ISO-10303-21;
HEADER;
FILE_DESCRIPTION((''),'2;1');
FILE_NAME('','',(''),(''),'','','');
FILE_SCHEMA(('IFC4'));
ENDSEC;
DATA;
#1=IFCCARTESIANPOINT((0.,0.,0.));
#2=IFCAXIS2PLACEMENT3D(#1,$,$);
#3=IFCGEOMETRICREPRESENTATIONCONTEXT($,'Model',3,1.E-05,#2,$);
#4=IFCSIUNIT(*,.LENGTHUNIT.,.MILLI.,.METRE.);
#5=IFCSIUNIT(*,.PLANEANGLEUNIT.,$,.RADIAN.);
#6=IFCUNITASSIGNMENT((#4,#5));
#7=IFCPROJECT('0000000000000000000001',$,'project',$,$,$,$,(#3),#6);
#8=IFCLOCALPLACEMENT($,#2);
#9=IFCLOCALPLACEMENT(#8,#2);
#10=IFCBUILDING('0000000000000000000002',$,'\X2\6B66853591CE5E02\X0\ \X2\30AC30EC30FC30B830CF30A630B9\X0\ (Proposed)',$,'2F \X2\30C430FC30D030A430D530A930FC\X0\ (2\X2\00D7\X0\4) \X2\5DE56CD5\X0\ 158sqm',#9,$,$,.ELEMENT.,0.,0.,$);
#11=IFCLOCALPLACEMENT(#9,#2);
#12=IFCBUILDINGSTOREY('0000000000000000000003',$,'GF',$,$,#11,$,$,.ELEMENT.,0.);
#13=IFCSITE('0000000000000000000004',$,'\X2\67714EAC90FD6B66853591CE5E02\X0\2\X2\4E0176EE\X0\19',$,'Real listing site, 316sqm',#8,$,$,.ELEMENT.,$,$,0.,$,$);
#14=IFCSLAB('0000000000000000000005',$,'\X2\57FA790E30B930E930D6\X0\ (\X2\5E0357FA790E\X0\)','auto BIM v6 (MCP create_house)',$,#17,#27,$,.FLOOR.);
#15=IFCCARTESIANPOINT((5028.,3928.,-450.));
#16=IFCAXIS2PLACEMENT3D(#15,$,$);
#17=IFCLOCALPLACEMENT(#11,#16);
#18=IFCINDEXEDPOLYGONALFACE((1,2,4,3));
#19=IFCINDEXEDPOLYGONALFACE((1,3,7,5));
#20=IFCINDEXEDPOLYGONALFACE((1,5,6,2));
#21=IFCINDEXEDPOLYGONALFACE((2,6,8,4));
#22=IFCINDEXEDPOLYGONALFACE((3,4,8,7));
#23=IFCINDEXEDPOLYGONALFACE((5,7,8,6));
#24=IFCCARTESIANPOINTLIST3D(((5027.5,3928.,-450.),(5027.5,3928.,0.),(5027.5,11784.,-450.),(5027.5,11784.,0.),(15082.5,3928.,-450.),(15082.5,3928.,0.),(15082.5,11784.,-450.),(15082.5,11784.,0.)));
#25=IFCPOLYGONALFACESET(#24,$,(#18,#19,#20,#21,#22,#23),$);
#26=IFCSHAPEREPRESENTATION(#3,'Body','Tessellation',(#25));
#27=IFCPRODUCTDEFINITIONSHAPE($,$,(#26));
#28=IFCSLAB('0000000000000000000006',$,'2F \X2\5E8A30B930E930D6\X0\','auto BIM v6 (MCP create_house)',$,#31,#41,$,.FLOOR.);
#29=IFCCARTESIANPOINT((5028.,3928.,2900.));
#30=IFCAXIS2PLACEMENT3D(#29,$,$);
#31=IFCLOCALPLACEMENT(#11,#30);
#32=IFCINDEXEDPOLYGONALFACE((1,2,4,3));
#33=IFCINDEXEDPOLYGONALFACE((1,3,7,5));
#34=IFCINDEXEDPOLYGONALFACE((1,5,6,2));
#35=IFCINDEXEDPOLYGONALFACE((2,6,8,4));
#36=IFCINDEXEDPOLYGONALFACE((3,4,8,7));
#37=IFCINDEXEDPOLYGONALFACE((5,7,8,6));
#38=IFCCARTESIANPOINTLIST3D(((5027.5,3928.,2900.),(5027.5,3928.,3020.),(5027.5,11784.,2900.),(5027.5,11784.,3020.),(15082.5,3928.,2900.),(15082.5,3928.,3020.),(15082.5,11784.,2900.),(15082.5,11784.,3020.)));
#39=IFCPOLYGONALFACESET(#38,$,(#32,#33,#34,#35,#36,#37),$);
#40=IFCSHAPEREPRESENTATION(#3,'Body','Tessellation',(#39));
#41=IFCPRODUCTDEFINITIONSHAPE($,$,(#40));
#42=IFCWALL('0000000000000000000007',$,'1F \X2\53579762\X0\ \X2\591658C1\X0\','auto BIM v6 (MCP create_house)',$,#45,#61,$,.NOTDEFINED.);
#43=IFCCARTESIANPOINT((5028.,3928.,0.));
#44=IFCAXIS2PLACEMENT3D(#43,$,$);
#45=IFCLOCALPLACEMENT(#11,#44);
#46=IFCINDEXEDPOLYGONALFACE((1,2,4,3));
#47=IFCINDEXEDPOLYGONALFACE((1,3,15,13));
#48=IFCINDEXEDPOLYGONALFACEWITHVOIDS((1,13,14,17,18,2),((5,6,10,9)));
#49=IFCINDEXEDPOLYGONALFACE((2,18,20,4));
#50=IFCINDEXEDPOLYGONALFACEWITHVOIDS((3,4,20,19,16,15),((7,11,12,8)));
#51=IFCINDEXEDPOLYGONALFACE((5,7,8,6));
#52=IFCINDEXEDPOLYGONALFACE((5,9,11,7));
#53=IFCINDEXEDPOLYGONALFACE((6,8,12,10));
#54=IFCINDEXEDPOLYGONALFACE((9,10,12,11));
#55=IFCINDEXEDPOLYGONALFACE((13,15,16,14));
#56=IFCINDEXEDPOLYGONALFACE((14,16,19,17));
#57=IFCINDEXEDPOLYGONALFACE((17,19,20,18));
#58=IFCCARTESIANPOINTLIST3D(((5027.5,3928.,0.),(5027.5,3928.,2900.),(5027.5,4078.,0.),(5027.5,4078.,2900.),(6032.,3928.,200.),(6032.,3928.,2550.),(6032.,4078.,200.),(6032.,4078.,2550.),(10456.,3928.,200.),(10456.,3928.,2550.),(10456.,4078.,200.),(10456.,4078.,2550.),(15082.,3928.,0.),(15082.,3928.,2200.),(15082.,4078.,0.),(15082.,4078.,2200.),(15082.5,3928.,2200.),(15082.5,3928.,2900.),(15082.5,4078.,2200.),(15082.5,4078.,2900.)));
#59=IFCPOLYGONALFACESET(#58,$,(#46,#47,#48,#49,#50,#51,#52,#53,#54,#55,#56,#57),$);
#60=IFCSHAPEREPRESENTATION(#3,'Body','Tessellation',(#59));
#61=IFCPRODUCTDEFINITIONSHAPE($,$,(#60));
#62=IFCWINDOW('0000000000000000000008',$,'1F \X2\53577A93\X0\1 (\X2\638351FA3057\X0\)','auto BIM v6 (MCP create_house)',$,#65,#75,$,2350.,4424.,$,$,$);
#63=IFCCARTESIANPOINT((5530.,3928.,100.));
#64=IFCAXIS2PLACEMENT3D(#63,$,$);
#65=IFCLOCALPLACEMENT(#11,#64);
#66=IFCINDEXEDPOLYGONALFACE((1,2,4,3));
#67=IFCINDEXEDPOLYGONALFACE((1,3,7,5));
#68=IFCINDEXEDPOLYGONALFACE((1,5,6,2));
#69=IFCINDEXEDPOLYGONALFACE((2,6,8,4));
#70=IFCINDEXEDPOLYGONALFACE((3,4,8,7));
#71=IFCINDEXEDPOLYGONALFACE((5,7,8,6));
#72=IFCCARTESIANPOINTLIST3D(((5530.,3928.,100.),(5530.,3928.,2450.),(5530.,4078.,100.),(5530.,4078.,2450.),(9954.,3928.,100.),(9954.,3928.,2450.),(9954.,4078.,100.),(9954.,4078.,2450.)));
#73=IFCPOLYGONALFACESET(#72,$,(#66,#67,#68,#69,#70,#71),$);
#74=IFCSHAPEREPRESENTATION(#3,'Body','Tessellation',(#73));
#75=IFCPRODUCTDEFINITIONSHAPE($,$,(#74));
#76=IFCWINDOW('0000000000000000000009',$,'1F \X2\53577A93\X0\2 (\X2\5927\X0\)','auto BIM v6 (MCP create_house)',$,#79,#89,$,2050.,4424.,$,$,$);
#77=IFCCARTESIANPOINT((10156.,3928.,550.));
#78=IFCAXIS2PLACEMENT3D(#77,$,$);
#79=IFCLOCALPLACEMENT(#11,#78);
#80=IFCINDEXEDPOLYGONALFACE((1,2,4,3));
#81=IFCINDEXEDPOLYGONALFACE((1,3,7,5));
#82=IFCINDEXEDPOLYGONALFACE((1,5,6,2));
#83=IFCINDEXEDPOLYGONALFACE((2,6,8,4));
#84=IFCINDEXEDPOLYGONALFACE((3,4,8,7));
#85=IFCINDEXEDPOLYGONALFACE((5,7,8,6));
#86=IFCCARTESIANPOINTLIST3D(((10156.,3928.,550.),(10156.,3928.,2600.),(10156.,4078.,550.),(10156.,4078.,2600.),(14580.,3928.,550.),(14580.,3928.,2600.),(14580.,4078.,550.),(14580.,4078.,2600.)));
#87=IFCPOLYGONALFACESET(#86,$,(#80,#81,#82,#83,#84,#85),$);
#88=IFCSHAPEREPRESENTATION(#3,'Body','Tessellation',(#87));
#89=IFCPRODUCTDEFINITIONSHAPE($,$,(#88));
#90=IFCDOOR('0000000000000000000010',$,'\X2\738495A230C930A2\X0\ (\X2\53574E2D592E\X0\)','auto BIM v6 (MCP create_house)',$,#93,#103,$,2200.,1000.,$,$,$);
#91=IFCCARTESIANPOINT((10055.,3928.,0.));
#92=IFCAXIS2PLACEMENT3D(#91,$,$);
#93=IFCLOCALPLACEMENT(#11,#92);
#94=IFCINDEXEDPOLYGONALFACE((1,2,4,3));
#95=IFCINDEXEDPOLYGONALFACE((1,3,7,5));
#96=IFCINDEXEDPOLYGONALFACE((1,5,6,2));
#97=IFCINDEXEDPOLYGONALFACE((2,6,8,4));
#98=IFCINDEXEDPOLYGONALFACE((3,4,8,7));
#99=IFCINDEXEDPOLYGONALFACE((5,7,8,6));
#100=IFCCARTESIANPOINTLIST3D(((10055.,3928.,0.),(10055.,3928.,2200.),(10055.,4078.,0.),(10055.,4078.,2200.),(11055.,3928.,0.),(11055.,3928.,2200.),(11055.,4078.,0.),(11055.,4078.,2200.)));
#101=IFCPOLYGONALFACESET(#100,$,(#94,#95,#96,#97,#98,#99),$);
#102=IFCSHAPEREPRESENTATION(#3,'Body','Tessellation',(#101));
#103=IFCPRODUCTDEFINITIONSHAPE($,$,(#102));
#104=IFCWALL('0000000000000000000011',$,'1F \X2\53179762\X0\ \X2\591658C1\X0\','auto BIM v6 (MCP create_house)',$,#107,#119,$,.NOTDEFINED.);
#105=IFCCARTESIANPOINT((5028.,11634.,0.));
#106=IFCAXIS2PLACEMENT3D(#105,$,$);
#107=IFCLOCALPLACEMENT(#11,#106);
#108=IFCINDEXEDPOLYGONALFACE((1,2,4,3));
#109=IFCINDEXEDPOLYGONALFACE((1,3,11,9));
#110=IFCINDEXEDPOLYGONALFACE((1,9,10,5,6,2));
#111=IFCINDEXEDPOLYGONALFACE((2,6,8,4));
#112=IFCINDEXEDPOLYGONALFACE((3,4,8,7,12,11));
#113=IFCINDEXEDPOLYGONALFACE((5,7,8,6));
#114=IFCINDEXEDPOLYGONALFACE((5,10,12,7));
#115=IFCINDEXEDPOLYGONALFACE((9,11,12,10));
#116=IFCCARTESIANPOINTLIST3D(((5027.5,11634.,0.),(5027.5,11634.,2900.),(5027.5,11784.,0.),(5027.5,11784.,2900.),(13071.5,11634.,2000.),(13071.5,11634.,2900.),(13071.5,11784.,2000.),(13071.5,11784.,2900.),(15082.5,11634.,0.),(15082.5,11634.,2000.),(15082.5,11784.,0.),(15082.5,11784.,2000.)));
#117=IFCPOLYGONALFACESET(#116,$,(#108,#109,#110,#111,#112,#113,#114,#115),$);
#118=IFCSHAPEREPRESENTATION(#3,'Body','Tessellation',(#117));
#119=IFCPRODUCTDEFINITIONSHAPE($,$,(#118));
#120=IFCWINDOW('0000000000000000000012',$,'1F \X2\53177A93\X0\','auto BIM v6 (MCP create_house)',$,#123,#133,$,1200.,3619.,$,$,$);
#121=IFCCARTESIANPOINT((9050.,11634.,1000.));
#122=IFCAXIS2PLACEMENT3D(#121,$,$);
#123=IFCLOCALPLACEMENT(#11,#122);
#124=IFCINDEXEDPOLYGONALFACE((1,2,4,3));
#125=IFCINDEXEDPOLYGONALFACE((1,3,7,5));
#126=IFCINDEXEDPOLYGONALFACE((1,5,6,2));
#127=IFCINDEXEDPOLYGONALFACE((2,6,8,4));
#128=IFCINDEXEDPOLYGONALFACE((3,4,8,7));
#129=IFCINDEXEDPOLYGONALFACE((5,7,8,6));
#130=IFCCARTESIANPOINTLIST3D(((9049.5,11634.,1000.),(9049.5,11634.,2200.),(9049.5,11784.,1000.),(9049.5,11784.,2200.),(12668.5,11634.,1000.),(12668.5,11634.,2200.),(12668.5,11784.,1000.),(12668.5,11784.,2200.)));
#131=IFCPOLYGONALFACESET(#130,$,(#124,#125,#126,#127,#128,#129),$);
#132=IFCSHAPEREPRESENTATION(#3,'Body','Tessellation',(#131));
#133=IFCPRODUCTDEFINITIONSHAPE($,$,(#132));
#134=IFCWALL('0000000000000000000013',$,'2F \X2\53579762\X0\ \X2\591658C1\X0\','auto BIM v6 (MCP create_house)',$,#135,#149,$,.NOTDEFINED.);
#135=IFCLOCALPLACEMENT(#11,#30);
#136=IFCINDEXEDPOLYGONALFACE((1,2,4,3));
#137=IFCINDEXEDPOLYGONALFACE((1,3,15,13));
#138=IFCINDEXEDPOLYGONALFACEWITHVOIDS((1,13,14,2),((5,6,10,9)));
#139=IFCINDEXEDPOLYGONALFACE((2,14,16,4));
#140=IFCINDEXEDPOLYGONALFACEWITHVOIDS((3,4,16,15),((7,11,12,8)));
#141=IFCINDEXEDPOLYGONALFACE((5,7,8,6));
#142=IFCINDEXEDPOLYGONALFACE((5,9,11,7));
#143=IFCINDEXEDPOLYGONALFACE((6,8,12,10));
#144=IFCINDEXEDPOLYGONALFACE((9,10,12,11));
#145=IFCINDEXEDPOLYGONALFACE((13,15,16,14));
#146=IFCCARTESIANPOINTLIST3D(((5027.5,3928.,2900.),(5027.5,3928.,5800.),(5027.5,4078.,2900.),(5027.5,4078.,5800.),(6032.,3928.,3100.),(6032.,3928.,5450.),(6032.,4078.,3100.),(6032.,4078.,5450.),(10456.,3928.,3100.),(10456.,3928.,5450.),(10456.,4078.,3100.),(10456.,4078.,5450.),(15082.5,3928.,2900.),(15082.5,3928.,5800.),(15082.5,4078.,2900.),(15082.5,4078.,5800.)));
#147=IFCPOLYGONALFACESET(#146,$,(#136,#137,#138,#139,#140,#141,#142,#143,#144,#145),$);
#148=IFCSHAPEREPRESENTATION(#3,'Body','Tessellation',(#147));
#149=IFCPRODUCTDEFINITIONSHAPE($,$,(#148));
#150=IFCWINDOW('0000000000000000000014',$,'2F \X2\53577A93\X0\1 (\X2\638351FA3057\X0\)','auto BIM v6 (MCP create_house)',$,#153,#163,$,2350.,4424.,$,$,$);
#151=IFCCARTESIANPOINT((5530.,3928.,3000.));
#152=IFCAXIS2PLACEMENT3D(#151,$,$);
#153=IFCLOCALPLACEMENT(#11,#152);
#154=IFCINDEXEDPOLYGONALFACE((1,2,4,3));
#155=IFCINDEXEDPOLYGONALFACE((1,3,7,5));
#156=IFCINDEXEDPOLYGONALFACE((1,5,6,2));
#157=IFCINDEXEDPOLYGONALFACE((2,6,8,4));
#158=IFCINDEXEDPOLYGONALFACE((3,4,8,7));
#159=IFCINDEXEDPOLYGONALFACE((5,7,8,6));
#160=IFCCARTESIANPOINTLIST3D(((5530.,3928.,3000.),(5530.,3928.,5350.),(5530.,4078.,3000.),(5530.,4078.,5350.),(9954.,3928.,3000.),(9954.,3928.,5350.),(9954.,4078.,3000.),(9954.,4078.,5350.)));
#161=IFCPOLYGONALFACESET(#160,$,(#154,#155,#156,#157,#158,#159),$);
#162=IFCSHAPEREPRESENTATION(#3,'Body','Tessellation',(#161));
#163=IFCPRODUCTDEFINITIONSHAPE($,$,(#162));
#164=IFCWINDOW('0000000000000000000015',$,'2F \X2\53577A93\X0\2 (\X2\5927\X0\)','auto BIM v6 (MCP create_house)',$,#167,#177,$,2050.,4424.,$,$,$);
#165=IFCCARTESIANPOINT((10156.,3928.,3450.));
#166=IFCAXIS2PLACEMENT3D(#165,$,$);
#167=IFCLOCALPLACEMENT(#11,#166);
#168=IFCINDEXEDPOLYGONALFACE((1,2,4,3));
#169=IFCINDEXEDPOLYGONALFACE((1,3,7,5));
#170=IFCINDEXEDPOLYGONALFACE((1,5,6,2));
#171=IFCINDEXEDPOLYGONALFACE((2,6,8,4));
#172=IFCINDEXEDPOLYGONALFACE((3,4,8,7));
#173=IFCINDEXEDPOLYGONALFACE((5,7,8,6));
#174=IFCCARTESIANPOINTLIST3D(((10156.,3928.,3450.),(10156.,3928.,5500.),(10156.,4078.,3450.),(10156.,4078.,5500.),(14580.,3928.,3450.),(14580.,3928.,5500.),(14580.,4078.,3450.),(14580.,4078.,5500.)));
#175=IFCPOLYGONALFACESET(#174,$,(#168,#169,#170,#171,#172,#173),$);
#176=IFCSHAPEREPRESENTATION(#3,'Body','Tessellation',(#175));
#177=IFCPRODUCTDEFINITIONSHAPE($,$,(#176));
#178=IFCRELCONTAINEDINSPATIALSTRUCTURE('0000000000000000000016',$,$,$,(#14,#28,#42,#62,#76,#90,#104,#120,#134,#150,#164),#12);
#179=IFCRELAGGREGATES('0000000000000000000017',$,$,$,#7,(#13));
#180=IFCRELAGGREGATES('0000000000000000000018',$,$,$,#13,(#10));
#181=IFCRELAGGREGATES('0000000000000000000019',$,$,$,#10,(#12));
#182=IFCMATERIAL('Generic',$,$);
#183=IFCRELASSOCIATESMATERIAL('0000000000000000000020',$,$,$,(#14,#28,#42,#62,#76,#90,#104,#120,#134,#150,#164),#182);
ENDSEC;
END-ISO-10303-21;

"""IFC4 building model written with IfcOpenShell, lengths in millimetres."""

from ifc_helpers import new_model, si_unit, frame, frame_2d, origin, place, context, project, spatial, rectangle, extrude, material, element, fill, save


model = new_model("IFC4")

# Units and contexts
model_context = context("Model", 3, precision=1e-05, world=origin())
ifc_project = project(units=[si_unit("LENGTHUNIT", "METRE", prefix="MILLI"), si_unit("PLANEANGLEUNIT", "RADIAN")], contexts=[model_context])

# Site, building, storey
site_placement = place(None, origin())
site = spatial("IfcSite", under=ifc_project, at=site_placement, Name="東京都武蔵野市2丁目19", ObjectType="Real listing site, 316sqm", CompositionType="ELEMENT", RefElevation=0.0)
building_placement = place(site_placement, origin())
building = spatial("IfcBuilding", under=site, at=building_placement, Name="武蔵野市 ガレージハウス (Proposed)", ObjectType="2F ツーバイフォー (2×4) 工法 158sqm", CompositionType="ELEMENT", ElevationOfRefHeight=0.0, ElevationOfTerrain=0.0)
storey_placement = place(building_placement, origin())
storey = spatial("IfcBuildingStorey", under=building, at=storey_placement, Name="GF", CompositionType="ELEMENT", Elevation=0.0)

# Slabs
ifc_material = material(Name="Generic")
slab_1_placement = place(storey_placement, frame((5028.0, 3928.0, -450.0)))
element("IfcSlab", 1, at=slab_1_placement, inside=storey, material=ifc_material, Name="基礎スラブ (布基礎)", Description="auto BIM v6 (MCP create_house)", PredefinedType="FLOOR", context=model_context, shape_type="SweptSolid", body=[
    extrude(rectangle(XDim=10055.0, YDim=7856.0, at=frame_2d((5027.0, 3928.0))), frame((5028.0, 3928.0, -450.0)), (0.0, 0.0, 1.0), 450.0),
])
slab_2_placement = place(storey_placement, frame((5028.0, 3928.0, 2900.0)))
element("IfcSlab", 2, at=slab_2_placement, inside=storey, material=ifc_material, Name="2F 床スラブ", Description="auto BIM v6 (MCP create_house)", PredefinedType="FLOOR", context=model_context, shape_type="SweptSolid", body=[
    extrude(rectangle(XDim=10055.0, YDim=7856.0, at=frame_2d((5027.0, 3928.0))), frame((5028.0, 3928.0, 2900.0)), (0.0, 0.0, 1.0), 120.0),
])

# Wall, openings, windows, door
wall_1_placement = place(storey_placement, frame((5028.0, 3928.0, 0.0)))
wall_1 = element("IfcWall", 3, at=wall_1_placement, inside=storey, material=ifc_material, Name="1F 南面 外壁", Description="auto BIM v6 (MCP create_house)", PredefinedType="NOTDEFINED", context=model_context, shape_type="SweptSolid", body=[
    extrude(rectangle(XDim=10055.0, YDim=150.0, at=frame_2d((5027.0, 75.0))), frame((5028.0, 3928.0, 0.0)), (0.0, 0.0, 1.0), 2900.0),
])
opening_1_placement = place(storey_placement, frame((5530.0, 3928.0, 100.0)))
opening_1 = element("IfcOpeningElement", 4, at=opening_1_placement, cuts=wall_1, PredefinedType="NOTDEFINED", context=model_context, shape_type="SweptSolid", body=[
    extrude(rectangle(XDim=4424.0, YDim=150.0, at=frame_2d((2212.0, 75.0))), frame((5530.0, 3928.0, 100.0)), (0.0, 0.0, 1.0), 2350.0),
])
opening_2_placement = place(storey_placement, frame((10156.0, 3928.0, 550.0)))
opening_2 = element("IfcOpeningElement", 5, at=opening_2_placement, cuts=wall_1, PredefinedType="NOTDEFINED", context=model_context, shape_type="SweptSolid", body=[
    extrude(rectangle(XDim=4424.0, YDim=150.0, at=frame_2d((2212.0, 75.0))), frame((10156.0, 3928.0, 550.0)), (0.0, 0.0, 1.0), 2050.0),
])
opening_3_placement = place(storey_placement, frame((10055.0, 3928.0, 0.0)))
opening_3 = element("IfcOpeningElement", 6, at=opening_3_placement, cuts=wall_1, PredefinedType="NOTDEFINED", context=model_context, shape_type="SweptSolid", body=[
    extrude(rectangle(XDim=1000.0, YDim=150.0, at=frame_2d((500.0, 75.0))), frame((10055.0, 3928.0, 0.0)), (0.0, 0.0, 1.0), 2200.0),
])
window_1_placement = place(storey_placement, frame((5530.0, 3928.0, 100.0)))
window_1 = element("IfcWindow", 7, at=window_1_placement, inside=storey, material=ifc_material, Name="1F 南窓1 (掃出し)", Description="auto BIM v6 (MCP create_house)", OverallHeight=2350.0, OverallWidth=4424.0, context=model_context, shape_type="SweptSolid", body=[
    extrude(rectangle(XDim=4424.0, YDim=150.0, at=frame_2d((2212.0, 75.0))), frame((5530.0, 3928.0, 100.0)), (0.0, 0.0, 1.0), 2350.0),
])
fill(opening_1, window_1)
window_2_placement = place(storey_placement, frame((10156.0, 3928.0, 550.0)))
window_2 = element("IfcWindow", 8, at=window_2_placement, inside=storey, material=ifc_material, Name="1F 南窓2 (大)", Description="auto BIM v6 (MCP create_house)", OverallHeight=2050.0, OverallWidth=4424.0, context=model_context, shape_type="SweptSolid", body=[
    extrude(rectangle(XDim=4424.0, YDim=150.0, at=frame_2d((2212.0, 75.0))), frame((10156.0, 3928.0, 550.0)), (0.0, 0.0, 1.0), 2050.0),
])
fill(opening_2, window_2)
door_placement = place(storey_placement, frame((10055.0, 3928.0, 0.0)))
door = element("IfcDoor", 9, at=door_placement, inside=storey, material=ifc_material, Name="玄関ドア (南中央)", Description="auto BIM v6 (MCP create_house)", OverallHeight=2200.0, OverallWidth=1000.0, context=model_context, shape_type="SweptSolid", body=[
    extrude(rectangle(XDim=1000.0, YDim=150.0, at=frame_2d((500.0, 75.0))), frame((10055.0, 3928.0, 0.0)), (0.0, 0.0, 1.0), 2200.0),
])
fill(opening_3, door)

# Wall, opening, window
wall_2_placement = place(storey_placement, frame((5028.0, 11634.0, 0.0)))
wall_2 = element("IfcWall", 10, at=wall_2_placement, inside=storey, material=ifc_material, Name="1F 北面 外壁", Description="auto BIM v6 (MCP create_house)", PredefinedType="NOTDEFINED", context=model_context, shape_type="SweptSolid", body=[
    extrude(rectangle(XDim=10055.0, YDim=150.0, at=frame_2d((5027.0, 75.0))), frame((5028.0, 11634.0, 0.0)), (0.0, 0.0, 1.0), 2900.0),
])
opening_4_placement = place(storey_placement, frame((9050.0, 11634.0, 1000.0)))
opening_4 = element("IfcOpeningElement", 11, at=opening_4_placement, cuts=wall_2, PredefinedType="NOTDEFINED", context=model_context, shape_type="SweptSolid", body=[
    extrude(rectangle(XDim=3619.0, YDim=150.0, at=frame_2d((1809.0, 75.0))), frame((9050.0, 11634.0, 1000.0)), (0.0, 0.0, 1.0), 1200.0),
])
window_3_placement = place(storey_placement, frame((9050.0, 11634.0, 1000.0)))
window_3 = element("IfcWindow", 12, at=window_3_placement, inside=storey, material=ifc_material, Name="1F 北窓", Description="auto BIM v6 (MCP create_house)", OverallHeight=1200.0, OverallWidth=3619.0, context=model_context, shape_type="SweptSolid", body=[
    extrude(rectangle(XDim=3619.0, YDim=150.0, at=frame_2d((1809.0, 75.0))), frame((9050.0, 11634.0, 1000.0)), (0.0, 0.0, 1.0), 1200.0),
])
fill(opening_4, window_3)

# Wall, openings, windows
wall_3_placement = place(storey_placement, frame((5028.0, 3928.0, 2900.0)))
wall_3 = element("IfcWall", 13, at=wall_3_placement, inside=storey, material=ifc_material, Name="2F 南面 外壁", Description="auto BIM v6 (MCP create_house)", PredefinedType="NOTDEFINED", context=model_context, shape_type="SweptSolid", body=[
    extrude(rectangle(XDim=10055.0, YDim=150.0, at=frame_2d((5027.0, 75.0))), frame((5028.0, 3928.0, 2900.0)), (0.0, 0.0, 1.0), 2900.0),
])
opening_5_placement = place(storey_placement, frame((5530.0, 3928.0, 3000.0)))
opening_5 = element("IfcOpeningElement", 14, at=opening_5_placement, cuts=wall_3, PredefinedType="NOTDEFINED", context=model_context, shape_type="SweptSolid", body=[
    extrude(rectangle(XDim=4424.0, YDim=150.0, at=frame_2d((2212.0, 75.0))), frame((5530.0, 3928.0, 3000.0)), (0.0, 0.0, 1.0), 2350.0),
])
opening_6_placement = place(storey_placement, frame((10156.0, 3928.0, 3450.0)))
opening_6 = element("IfcOpeningElement", 15, at=opening_6_placement, cuts=wall_3, PredefinedType="NOTDEFINED", context=model_context, shape_type="SweptSolid", body=[
    extrude(rectangle(XDim=4424.0, YDim=150.0, at=frame_2d((2212.0, 75.0))), frame((10156.0, 3928.0, 3450.0)), (0.0, 0.0, 1.0), 2050.0),
])
window_4_placement = place(storey_placement, frame((5530.0, 3928.0, 3000.0)))
window_4 = element("IfcWindow", 16, at=window_4_placement, inside=storey, material=ifc_material, Name="2F 南窓1 (掃出し)", Description="auto BIM v6 (MCP create_house)", OverallHeight=2350.0, OverallWidth=4424.0, context=model_context, shape_type="SweptSolid", body=[
    extrude(rectangle(XDim=4424.0, YDim=150.0, at=frame_2d((2212.0, 75.0))), frame((5530.0, 3928.0, 3000.0)), (0.0, 0.0, 1.0), 2350.0),
])
fill(opening_5, window_4)
window_5_placement = place(storey_placement, frame((10156.0, 3928.0, 3450.0)))
window_5 = element("IfcWindow", 17, at=window_5_placement, inside=storey, material=ifc_material, Name="2F 南窓2 (大)", Description="auto BIM v6 (MCP create_house)", OverallHeight=2050.0, OverallWidth=4424.0, context=model_context, shape_type="SweptSolid", body=[
    extrude(rectangle(XDim=4424.0, YDim=150.0, at=frame_2d((2212.0, 75.0))), frame((10156.0, 3928.0, 3450.0)), (0.0, 0.0, 1.0), 2050.0),
])
fill(opening_6, window_5)

save(model, "model.ifc")
